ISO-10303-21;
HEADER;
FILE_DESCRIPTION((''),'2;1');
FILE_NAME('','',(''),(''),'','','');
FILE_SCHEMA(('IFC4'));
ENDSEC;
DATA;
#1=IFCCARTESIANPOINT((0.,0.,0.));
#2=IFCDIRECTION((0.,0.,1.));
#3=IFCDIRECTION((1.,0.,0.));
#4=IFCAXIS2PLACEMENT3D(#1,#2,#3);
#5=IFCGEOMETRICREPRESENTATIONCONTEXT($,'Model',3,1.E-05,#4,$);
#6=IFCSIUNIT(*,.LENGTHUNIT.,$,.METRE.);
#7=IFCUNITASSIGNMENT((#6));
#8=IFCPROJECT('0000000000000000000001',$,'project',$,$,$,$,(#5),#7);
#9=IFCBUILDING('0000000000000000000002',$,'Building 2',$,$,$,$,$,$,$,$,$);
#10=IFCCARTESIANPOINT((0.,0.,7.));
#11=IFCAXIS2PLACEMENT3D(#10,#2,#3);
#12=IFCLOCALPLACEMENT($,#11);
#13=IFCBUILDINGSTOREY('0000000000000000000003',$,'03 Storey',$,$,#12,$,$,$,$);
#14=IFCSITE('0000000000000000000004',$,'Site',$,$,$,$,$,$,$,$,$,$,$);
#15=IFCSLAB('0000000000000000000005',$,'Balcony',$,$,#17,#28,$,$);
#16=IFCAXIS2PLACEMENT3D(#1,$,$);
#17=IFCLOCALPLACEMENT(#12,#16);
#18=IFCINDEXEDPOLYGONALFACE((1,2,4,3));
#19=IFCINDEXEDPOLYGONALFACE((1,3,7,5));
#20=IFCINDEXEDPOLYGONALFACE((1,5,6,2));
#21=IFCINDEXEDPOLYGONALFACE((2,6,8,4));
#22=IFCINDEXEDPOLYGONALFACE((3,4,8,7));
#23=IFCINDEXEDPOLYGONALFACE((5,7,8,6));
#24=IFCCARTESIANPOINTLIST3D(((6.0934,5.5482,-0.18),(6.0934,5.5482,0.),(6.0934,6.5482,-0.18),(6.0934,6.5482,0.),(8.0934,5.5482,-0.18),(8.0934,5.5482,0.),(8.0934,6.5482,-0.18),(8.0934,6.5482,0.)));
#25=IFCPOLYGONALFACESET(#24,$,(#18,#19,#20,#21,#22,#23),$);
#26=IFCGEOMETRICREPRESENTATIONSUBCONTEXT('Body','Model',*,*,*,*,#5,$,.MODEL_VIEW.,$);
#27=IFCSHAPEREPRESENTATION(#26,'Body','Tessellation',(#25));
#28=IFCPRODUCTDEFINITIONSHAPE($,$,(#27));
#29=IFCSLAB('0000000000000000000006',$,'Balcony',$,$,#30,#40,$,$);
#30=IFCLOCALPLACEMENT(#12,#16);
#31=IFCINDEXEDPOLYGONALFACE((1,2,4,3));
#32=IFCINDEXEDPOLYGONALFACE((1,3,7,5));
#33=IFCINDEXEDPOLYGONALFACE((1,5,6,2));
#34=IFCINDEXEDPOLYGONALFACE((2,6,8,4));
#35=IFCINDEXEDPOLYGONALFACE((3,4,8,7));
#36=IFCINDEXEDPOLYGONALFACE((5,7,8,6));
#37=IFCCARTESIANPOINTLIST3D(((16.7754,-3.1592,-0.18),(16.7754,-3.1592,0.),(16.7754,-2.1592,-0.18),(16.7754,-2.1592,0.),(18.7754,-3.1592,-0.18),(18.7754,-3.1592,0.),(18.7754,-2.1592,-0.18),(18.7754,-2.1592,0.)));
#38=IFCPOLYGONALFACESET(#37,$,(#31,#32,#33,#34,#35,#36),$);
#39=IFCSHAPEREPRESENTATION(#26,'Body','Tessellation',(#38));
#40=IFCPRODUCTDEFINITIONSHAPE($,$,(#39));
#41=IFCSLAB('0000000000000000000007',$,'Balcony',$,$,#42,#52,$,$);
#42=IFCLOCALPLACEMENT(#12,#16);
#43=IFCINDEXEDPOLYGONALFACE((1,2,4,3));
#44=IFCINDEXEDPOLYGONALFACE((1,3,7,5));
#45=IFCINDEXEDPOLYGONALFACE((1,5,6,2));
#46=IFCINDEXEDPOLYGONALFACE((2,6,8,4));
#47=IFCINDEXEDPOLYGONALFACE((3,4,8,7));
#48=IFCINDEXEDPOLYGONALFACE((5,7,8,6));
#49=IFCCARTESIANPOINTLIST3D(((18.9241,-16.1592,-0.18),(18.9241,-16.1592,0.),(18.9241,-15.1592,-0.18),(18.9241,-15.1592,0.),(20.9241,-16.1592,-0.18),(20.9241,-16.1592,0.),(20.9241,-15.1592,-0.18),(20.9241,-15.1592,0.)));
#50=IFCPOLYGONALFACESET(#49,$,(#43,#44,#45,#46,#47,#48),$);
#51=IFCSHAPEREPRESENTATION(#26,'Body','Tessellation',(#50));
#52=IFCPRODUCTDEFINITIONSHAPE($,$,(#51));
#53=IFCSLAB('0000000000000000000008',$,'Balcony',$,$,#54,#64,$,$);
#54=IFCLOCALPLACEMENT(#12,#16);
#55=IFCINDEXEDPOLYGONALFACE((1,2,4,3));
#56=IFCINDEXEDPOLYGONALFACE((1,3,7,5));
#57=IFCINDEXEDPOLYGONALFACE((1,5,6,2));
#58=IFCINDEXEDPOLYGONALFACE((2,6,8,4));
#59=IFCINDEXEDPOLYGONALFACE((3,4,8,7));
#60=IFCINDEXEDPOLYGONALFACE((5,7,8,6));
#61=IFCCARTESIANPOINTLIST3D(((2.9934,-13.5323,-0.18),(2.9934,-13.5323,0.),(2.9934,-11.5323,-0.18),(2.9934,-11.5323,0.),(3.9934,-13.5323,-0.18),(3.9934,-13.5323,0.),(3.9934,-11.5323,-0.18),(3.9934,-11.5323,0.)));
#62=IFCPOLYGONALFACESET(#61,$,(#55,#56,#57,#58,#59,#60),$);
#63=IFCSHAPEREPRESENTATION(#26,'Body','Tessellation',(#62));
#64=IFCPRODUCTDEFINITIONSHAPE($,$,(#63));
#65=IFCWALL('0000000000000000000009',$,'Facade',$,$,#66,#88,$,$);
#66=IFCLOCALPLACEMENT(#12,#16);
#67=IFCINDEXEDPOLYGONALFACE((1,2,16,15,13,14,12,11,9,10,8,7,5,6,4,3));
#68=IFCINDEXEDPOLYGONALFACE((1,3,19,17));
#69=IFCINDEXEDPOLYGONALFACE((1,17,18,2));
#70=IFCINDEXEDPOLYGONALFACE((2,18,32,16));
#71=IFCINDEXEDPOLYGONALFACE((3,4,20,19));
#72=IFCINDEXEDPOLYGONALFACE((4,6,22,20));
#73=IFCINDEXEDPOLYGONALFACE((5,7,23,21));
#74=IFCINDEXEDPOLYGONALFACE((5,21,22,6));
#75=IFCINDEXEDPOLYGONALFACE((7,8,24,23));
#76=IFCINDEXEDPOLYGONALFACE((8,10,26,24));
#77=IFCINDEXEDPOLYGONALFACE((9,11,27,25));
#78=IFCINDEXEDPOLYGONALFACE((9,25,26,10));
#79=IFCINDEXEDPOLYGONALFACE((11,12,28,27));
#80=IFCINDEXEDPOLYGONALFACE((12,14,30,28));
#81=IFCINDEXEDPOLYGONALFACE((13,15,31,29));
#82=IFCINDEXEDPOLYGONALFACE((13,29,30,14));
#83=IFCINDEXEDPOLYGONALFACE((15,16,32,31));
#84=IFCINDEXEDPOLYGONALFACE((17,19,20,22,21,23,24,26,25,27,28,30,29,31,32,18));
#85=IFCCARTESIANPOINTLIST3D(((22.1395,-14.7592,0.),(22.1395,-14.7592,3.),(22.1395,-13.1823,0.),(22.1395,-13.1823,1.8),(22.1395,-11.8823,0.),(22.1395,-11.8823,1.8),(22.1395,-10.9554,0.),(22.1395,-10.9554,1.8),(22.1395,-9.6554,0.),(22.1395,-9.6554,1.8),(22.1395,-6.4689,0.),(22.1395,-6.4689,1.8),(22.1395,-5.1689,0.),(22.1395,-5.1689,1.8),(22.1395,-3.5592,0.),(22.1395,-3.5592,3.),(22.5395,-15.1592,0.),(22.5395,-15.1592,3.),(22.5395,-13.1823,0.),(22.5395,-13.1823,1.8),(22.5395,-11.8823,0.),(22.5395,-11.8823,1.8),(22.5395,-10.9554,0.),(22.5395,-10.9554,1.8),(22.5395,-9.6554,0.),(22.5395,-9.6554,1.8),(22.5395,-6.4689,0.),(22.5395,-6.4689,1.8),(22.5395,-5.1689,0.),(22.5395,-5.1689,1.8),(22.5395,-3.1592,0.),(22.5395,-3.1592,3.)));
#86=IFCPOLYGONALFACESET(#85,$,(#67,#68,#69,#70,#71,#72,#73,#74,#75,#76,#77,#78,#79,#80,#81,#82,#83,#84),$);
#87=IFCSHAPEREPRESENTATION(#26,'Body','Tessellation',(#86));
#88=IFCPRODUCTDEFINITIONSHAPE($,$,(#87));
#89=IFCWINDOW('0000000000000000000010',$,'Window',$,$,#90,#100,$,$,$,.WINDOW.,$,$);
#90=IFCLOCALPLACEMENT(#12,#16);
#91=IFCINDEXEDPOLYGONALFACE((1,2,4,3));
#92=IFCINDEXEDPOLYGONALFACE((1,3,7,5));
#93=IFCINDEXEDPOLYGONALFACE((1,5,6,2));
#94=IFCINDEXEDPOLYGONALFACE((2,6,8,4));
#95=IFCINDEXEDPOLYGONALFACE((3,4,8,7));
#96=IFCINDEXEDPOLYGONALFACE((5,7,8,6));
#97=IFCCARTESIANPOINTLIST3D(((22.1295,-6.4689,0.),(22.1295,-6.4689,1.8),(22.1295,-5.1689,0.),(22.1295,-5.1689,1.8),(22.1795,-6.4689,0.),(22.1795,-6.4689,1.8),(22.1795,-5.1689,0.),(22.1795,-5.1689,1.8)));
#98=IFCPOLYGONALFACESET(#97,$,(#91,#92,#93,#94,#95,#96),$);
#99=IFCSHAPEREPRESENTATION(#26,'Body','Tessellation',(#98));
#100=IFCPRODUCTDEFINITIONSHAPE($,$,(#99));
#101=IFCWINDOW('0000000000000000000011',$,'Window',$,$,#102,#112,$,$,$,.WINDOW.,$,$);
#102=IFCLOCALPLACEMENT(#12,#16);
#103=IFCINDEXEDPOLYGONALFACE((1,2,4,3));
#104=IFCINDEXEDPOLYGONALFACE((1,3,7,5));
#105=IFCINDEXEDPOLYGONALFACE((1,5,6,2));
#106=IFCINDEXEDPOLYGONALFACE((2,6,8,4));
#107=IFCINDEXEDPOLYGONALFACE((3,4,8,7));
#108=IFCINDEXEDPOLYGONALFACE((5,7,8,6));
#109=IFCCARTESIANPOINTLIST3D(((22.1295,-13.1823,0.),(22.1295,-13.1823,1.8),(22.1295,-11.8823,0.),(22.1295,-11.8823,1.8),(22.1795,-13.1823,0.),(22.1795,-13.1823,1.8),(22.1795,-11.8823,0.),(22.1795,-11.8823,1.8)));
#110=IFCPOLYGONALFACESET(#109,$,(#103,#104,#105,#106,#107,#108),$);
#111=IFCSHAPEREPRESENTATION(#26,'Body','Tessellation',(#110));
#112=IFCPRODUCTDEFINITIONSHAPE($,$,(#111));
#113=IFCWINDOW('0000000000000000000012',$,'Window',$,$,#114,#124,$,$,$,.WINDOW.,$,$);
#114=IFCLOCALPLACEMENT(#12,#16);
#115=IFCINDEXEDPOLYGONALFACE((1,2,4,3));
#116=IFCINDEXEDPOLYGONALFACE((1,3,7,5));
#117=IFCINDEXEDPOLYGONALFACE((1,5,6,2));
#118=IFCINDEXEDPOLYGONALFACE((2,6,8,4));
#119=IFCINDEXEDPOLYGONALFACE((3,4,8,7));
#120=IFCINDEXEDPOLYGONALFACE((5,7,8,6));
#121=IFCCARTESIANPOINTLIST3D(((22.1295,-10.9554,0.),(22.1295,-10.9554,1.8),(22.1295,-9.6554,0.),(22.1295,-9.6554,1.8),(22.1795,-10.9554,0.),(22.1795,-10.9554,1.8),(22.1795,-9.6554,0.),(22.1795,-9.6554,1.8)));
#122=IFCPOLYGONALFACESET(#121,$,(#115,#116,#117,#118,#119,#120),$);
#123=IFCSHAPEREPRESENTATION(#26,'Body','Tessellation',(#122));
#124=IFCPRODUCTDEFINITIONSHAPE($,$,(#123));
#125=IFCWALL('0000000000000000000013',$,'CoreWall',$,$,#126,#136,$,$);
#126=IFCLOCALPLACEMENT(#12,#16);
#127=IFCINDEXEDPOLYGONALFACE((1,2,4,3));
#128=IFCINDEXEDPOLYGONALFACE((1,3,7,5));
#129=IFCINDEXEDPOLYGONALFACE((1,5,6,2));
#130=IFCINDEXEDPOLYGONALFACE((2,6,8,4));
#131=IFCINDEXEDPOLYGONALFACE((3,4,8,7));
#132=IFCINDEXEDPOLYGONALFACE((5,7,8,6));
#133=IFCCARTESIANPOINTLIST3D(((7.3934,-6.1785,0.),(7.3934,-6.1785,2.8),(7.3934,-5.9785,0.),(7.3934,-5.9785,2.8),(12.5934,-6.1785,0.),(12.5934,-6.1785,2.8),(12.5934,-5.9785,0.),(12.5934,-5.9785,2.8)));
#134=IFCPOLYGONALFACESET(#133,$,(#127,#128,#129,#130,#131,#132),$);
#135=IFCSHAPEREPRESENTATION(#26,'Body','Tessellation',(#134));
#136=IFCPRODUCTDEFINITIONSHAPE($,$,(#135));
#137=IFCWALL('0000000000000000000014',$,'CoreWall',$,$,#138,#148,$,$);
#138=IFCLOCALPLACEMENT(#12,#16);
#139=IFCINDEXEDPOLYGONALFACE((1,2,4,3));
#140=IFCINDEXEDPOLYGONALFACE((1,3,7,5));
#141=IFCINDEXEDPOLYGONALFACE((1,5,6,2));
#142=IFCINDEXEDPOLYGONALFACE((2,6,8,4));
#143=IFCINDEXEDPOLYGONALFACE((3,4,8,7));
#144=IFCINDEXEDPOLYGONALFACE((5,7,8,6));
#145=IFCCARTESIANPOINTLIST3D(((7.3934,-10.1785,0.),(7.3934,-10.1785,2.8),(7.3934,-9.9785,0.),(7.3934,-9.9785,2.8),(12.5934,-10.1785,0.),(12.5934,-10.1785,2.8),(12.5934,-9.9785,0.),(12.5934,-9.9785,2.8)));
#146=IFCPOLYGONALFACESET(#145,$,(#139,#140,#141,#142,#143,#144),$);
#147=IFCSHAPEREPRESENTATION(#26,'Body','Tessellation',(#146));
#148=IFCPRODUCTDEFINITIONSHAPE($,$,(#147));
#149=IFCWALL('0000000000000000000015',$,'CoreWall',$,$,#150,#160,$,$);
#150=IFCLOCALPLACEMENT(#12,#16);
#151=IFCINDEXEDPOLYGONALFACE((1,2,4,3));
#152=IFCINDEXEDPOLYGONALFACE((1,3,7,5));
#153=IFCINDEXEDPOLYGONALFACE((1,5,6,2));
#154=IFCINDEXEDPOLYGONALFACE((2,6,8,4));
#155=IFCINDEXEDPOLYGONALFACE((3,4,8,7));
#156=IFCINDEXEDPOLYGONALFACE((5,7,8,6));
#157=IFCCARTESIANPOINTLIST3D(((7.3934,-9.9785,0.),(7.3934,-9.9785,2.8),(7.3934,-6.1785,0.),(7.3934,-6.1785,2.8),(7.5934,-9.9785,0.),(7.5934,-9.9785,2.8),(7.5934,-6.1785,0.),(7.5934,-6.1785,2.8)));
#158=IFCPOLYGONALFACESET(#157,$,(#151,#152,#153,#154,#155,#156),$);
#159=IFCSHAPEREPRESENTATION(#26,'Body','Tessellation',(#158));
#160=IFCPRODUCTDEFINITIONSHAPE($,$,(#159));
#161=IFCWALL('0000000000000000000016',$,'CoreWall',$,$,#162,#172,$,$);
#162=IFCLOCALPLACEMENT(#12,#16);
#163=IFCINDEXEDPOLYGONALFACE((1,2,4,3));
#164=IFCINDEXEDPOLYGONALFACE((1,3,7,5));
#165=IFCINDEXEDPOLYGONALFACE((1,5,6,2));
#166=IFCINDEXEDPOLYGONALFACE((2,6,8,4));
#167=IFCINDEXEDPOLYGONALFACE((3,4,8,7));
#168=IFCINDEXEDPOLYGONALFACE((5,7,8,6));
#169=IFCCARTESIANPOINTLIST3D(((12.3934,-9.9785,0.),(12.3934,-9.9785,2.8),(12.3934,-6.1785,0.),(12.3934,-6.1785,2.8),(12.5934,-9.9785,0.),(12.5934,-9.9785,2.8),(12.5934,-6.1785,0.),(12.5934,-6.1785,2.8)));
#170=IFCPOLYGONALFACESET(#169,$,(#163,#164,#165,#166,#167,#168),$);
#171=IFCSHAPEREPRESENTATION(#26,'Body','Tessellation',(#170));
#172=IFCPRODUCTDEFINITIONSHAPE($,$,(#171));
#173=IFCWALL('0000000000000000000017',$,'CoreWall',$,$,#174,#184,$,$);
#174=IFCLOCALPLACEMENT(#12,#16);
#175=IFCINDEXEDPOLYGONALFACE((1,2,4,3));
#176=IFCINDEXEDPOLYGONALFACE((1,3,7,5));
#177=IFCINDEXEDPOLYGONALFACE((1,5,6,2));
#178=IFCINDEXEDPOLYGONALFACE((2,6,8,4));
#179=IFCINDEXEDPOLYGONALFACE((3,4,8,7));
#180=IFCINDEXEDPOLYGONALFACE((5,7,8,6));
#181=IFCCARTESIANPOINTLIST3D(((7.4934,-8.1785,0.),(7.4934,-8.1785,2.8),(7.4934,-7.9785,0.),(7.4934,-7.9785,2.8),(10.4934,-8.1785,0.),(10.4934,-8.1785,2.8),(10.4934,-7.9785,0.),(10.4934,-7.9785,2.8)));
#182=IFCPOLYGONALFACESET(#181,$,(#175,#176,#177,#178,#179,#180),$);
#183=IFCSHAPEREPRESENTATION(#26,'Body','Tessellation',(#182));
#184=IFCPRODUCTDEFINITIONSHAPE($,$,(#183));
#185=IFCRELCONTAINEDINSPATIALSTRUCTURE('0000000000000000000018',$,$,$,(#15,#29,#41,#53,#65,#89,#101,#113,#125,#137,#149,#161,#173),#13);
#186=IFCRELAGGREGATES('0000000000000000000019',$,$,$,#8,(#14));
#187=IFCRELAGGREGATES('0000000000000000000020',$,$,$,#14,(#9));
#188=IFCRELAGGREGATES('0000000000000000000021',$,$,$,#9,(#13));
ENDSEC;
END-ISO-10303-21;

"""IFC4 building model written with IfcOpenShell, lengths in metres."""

from ifc_helpers import new_model, si_unit, frame, origin_with_axes, place, context, subcontext, project, spatial, line, indexed_curve, outline, extrude, element, fill, save


model = new_model("IFC4")

# Units and contexts
model_context = context("Model", 3, precision=1e-05, world=origin_with_axes())
body_context = subcontext(model_context, "Body", "Model", "MODEL_VIEW")
ifc_project = project(units=[si_unit("LENGTHUNIT", "METRE")], contexts=[model_context])

# Site, building, storey
site = spatial("IfcSite", under=ifc_project, Name="Site")
building = spatial("IfcBuilding", under=site, Name="Building 2")
storey_placement = place(None, frame((0.0, 0.0, 7.0), z_axis=(0.0, 0.0, 1.0), x_axis=(1.0, 0.0, 0.0)))
storey = spatial("IfcBuildingStorey", under=building, at=storey_placement, Name="03 Storey")

# Slabs
slab_1_placement = place(storey_placement, origin_with_axes())
element("IfcSlab", 1, at=slab_1_placement, inside=storey, Name="Balcony", context=body_context, shape_type="SweptSolid", body=[
    extrude(outline(indexed_curve([(6.0934, 5.5482), (6.0934, 6.5482), (8.0934, 6.5482), (8.0934, 5.5482)], segments=[line(1, 2), line(2, 3), line(3, 4)])), origin_with_axes(), (0.0, 0.0, -1.0), 0.18),
])
slab_2_placement = place(storey_placement, origin_with_axes())
element("IfcSlab", 2, at=slab_2_placement, inside=storey, Name="Balcony", context=body_context, shape_type="SweptSolid", body=[
    extrude(outline(indexed_curve([(16.7754, -3.1592), (16.7754, -2.1592), (18.7754, -2.1592), (18.7754, -3.1592)], segments=[line(1, 2), line(2, 3), line(3, 4)])), origin_with_axes(), (0.0, 0.0, -1.0), 0.18),
])
slab_3_placement = place(storey_placement, origin_with_axes())
element("IfcSlab", 3, at=slab_3_placement, inside=storey, Name="Balcony", context=body_context, shape_type="SweptSolid", body=[
    extrude(outline(indexed_curve([(20.9241, -15.1592), (20.9241, -16.1592), (18.9241, -16.1592), (18.9241, -15.1592)], segments=[line(1, 2), line(2, 3), line(3, 4)])), origin_with_axes(), (0.0, 0.0, -1.0), 0.18),
])
slab_4_placement = place(storey_placement, origin_with_axes())
element("IfcSlab", 4, at=slab_4_placement, inside=storey, Name="Balcony", context=body_context, shape_type="SweptSolid", body=[
    extrude(outline(indexed_curve([(3.9934, -13.5323), (2.9934, -13.5323), (2.9934, -11.5323), (3.9934, -11.5323)], segments=[line(1, 2), line(2, 3), line(3, 4)])), origin_with_axes(), (0.0, 0.0, -1.0), 0.18),
])

# Wall, openings, windows
wall_1_placement = place(storey_placement, origin_with_axes())
wall_1 = element("IfcWall", 5, at=wall_1_placement, inside=storey, Name="Facade", context=body_context, shape_type="SweptSolid", body=[
    extrude(outline(indexed_curve([(22.1395, -14.7592), (22.1395, -3.5592), (22.5395, -3.1592), (22.5395, -15.1592)], segments=[line(1, 2), line(2, 3), line(3, 4)])), origin_with_axes(), (0.0, 0.0, 1.0), 3.0),
])
opening_1_placement = place(wall_1_placement, origin_with_axes())
opening_1 = element("IfcOpeningElement", 6, at=opening_1_placement, cuts=wall_1, context=body_context, shape_type="SweptSolid", body=[
    extrude(outline(indexed_curve([(22.5795, -6.4689), (22.0795, -6.4689), (22.0795, -5.1689), (22.5795, -5.1689)], segments=[line(1, 2), line(2, 3), line(3, 4)])), origin_with_axes(), (0.0, 0.0, 1.0), 1.8),
])
opening_2_placement = place(wall_1_placement, origin_with_axes())
opening_2 = element("IfcOpeningElement", 7, at=opening_2_placement, cuts=wall_1, context=body_context, shape_type="SweptSolid", body=[
    extrude(outline(indexed_curve([(22.5795, -13.1823), (22.0795, -13.1823), (22.0795, -11.8823), (22.5795, -11.8823)], segments=[line(1, 2), line(2, 3), line(3, 4)])), origin_with_axes(), (0.0, 0.0, 1.0), 1.8),
])
opening_3_placement = place(wall_1_placement, origin_with_axes())
opening_3 = element("IfcOpeningElement", 8, at=opening_3_placement, cuts=wall_1, context=body_context, shape_type="SweptSolid", body=[
    extrude(outline(indexed_curve([(22.5795, -10.9554), (22.0795, -10.9554), (22.0795, -9.6554), (22.5795, -9.6554)], segments=[line(1, 2), line(2, 3), line(3, 4)])), origin_with_axes(), (0.0, 0.0, 1.0), 1.8),
])
window_1_placement = place(storey_placement, origin_with_axes())
window_1 = element("IfcWindow", 9, at=window_1_placement, inside=storey, Name="Window", PredefinedType="WINDOW", context=body_context, shape_type="SweptSolid", body=[
    extrude(outline(indexed_curve([(22.1795, -6.4689), (22.1295, -6.4689), (22.1295, -5.1689), (22.1795, -5.1689)], segments=[line(1, 2), line(2, 3), line(3, 4)])), origin_with_axes(), (0.0, 0.0, 1.0), 1.8),
])
fill(opening_1, window_1)
window_2_placement = place(storey_placement, origin_with_axes())
window_2 = element("IfcWindow", 10, at=window_2_placement, inside=storey, Name="Window", PredefinedType="WINDOW", context=body_context, shape_type="SweptSolid", body=[
    extrude(outline(indexed_curve([(22.1795, -13.1823), (22.1295, -13.1823), (22.1295, -11.8823), (22.1795, -11.8823)], segments=[line(1, 2), line(2, 3), line(3, 4)])), origin_with_axes(), (0.0, 0.0, 1.0), 1.8),
])
fill(opening_2, window_2)
window_3_placement = place(storey_placement, origin_with_axes())
window_3 = element("IfcWindow", 11, at=window_3_placement, inside=storey, Name="Window", PredefinedType="WINDOW", context=body_context, shape_type="SweptSolid", body=[
    extrude(outline(indexed_curve([(22.1795, -10.9554), (22.1295, -10.9554), (22.1295, -9.6554), (22.1795, -9.6554)], segments=[line(1, 2), line(2, 3), line(3, 4)])), origin_with_axes(), (0.0, 0.0, 1.0), 1.8),
])
fill(opening_3, window_3)

# Walls
wall_2_placement = place(storey_placement, origin_with_axes())
element("IfcWall", 12, at=wall_2_placement, inside=storey, Name="CoreWall", context=body_context, shape_type="SweptSolid", body=[
    extrude(outline(indexed_curve([(12.5934, -5.9785), (7.3934, -5.9785), (7.3934, -6.1785), (12.5934, -6.1785)], segments=[line(1, 2), line(2, 3), line(3, 4)])), origin_with_axes(), (0.0, 0.0, 1.0), 2.8),
])
wall_3_placement = place(storey_placement, origin_with_axes())
element("IfcWall", 13, at=wall_3_placement, inside=storey, Name="CoreWall", context=body_context, shape_type="SweptSolid", body=[
    extrude(outline(indexed_curve([(7.3934, -10.1785), (12.5934, -10.1785), (12.5934, -9.9785), (7.3934, -9.9785)], segments=[line(1, 2), line(2, 3), line(3, 4)])), origin_with_axes(), (0.0, 0.0, 1.0), 2.8),
])
wall_4_placement = place(storey_placement, origin_with_axes())
element("IfcWall", 14, at=wall_4_placement, inside=storey, Name="CoreWall", context=body_context, shape_type="SweptSolid", body=[
    extrude(outline(indexed_curve([(7.5934, -9.9785), (7.5934, -6.1785), (7.3934, -6.1785), (7.3934, -9.9785)], segments=[line(1, 2), line(2, 3), line(3, 4)])), origin_with_axes(), (0.0, 0.0, 1.0), 2.8),
])
wall_5_placement = place(storey_placement, origin_with_axes())
element("IfcWall", 15, at=wall_5_placement, inside=storey, Name="CoreWall", context=body_context, shape_type="SweptSolid", body=[
    extrude(outline(indexed_curve([(12.3934, -6.1785), (12.3934, -9.9785), (12.5934, -9.9785), (12.5934, -6.1785)], segments=[line(1, 2), line(2, 3), line(3, 4)])), origin_with_axes(), (0.0, 0.0, 1.0), 2.8),
])
wall_6_placement = place(storey_placement, origin_with_axes())
element("IfcWall", 16, at=wall_6_placement, inside=storey, Name="CoreWall", context=body_context, shape_type="SweptSolid", body=[
    extrude(outline(indexed_curve([(10.4934, -7.9785), (7.4934, -7.9785), (7.4934, -8.1785), (10.4934, -8.1785)], segments=[line(1, 2), line(2, 3), line(3, 4)])), origin_with_axes(), (0.0, 0.0, 1.0), 2.8),
])

save(model, "model.ifc")
